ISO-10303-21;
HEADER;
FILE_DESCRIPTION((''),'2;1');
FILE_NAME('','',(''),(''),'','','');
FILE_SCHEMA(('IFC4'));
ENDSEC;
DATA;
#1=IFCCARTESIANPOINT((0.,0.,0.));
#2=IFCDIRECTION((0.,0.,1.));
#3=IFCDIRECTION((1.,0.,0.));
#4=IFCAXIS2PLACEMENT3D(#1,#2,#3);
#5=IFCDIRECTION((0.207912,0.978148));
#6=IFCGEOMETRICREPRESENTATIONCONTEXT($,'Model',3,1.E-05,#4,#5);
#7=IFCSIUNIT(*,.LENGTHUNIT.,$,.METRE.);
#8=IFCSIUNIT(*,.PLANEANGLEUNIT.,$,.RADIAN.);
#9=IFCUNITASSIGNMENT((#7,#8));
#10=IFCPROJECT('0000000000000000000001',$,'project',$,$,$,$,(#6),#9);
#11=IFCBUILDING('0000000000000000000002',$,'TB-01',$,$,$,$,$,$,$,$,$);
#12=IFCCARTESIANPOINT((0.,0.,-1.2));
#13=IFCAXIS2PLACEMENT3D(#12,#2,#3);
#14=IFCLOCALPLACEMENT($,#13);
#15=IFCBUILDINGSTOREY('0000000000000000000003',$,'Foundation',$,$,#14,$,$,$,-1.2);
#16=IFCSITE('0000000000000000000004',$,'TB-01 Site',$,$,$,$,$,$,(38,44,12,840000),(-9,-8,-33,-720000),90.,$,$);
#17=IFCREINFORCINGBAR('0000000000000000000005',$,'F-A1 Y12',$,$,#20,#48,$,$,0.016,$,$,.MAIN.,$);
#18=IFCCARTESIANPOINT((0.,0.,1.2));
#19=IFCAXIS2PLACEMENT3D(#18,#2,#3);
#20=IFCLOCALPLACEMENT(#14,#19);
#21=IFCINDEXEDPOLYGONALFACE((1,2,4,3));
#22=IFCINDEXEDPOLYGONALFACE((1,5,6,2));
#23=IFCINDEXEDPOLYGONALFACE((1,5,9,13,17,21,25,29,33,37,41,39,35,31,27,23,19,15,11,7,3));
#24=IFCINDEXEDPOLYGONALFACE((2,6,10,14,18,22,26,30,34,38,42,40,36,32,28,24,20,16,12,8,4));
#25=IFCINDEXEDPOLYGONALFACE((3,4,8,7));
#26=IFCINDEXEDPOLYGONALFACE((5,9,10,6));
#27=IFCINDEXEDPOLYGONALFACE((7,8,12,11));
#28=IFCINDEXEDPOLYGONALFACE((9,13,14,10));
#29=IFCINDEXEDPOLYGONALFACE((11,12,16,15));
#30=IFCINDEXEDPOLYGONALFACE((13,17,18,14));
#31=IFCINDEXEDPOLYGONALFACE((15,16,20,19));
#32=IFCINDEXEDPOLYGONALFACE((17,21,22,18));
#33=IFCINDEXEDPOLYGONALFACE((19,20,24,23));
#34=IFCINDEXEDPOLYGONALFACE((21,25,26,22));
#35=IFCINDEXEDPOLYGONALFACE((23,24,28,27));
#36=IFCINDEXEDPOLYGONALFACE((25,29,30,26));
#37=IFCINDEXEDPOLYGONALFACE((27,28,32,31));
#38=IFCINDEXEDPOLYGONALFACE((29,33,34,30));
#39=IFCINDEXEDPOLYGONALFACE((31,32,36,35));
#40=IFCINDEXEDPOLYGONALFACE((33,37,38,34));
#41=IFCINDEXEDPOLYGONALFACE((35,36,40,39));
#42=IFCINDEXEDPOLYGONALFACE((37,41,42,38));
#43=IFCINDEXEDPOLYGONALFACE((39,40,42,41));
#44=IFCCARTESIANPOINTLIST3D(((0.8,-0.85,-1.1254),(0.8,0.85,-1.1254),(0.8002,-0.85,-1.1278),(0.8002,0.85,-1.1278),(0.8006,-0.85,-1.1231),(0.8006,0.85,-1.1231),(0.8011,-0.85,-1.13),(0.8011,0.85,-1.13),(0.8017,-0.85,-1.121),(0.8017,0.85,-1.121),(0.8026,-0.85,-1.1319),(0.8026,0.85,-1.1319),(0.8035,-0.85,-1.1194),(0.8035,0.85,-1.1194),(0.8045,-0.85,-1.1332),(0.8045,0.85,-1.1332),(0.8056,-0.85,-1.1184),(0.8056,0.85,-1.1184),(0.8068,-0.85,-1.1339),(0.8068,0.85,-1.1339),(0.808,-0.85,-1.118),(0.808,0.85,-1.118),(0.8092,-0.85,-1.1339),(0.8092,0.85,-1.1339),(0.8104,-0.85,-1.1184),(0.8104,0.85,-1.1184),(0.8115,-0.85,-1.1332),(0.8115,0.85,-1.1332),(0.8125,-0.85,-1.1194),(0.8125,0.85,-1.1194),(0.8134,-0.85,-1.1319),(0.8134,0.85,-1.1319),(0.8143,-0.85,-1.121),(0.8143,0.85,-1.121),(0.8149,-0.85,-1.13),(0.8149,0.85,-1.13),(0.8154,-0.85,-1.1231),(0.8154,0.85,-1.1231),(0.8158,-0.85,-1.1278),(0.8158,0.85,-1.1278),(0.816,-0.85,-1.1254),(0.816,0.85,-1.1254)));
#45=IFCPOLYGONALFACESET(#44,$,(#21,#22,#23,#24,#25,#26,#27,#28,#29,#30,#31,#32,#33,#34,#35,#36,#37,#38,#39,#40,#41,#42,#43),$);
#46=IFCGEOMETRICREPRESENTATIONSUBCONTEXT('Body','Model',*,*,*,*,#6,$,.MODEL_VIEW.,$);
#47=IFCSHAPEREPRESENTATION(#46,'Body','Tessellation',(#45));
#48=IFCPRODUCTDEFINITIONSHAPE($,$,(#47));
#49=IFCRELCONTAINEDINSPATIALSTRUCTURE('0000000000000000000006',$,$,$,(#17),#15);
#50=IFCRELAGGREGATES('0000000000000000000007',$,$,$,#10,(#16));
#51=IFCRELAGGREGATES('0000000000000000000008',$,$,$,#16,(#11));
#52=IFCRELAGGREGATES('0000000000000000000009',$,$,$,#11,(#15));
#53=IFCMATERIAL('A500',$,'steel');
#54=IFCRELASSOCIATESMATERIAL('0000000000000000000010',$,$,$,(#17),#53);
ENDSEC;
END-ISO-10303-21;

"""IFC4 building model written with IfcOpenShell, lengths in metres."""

from ifc_helpers import new_model, entity, si_unit, direction, frame, origin_with_axes, place, context, subcontext, project, spatial, material, element, save


model = new_model("IFC4")

# Units and contexts
model_context = context("Model", 3, precision=1e-05, world=origin_with_axes(), true_north=direction((0.207912, 0.978148)))
body_context = subcontext(model_context, "Body", "Model", "MODEL_VIEW")
ifc_project = project(units=[si_unit("LENGTHUNIT", "METRE"), si_unit("PLANEANGLEUNIT", "RADIAN")], contexts=[model_context])

# Site, building, storey
site = spatial("IfcSite", under=ifc_project, Name="TB-01 Site", RefLatitude=(38, 44, 12, 840000), RefLongitude=(-9, -8, -33, -720000), RefElevation=90.0)
building = spatial("IfcBuilding", under=site, Name="TB-01")
storey_placement = place(None, frame((0.0, 0.0, -1.2), z_axis=(0.0, 0.0, 1.0), x_axis=(1.0, 0.0, 0.0)))
storey = spatial("IfcBuildingStorey", under=building, at=storey_placement, Name="Foundation", Elevation=-1.2)

# Reinforcing bar
ifc_material_1 = material(Name="A500", Category="steel")
reinforcing_bar_1_placement = place(storey_placement, frame((0.0, 0.0, 1.2), z_axis=(0.0, 0.0, 1.0), x_axis=(1.0, 0.0, 0.0)))
element("IfcReinforcingBar", 1, at=reinforcing_bar_1_placement, inside=storey, material=ifc_material_1, Name="F-A1 Y12", NominalDiameter=0.016, PredefinedType="MAIN", context=body_context, shape_type="AdvancedSweptSolid", body=[
    entity("IfcSweptDiskSolid", entity("IfcPolyline", [entity("IfcCartesianPoint", [0.808, -0.85, -1.126]), entity("IfcCartesianPoint", [0.808, 0.85, -1.126])]), 0.008),
])

save(model, "model.ifc")
